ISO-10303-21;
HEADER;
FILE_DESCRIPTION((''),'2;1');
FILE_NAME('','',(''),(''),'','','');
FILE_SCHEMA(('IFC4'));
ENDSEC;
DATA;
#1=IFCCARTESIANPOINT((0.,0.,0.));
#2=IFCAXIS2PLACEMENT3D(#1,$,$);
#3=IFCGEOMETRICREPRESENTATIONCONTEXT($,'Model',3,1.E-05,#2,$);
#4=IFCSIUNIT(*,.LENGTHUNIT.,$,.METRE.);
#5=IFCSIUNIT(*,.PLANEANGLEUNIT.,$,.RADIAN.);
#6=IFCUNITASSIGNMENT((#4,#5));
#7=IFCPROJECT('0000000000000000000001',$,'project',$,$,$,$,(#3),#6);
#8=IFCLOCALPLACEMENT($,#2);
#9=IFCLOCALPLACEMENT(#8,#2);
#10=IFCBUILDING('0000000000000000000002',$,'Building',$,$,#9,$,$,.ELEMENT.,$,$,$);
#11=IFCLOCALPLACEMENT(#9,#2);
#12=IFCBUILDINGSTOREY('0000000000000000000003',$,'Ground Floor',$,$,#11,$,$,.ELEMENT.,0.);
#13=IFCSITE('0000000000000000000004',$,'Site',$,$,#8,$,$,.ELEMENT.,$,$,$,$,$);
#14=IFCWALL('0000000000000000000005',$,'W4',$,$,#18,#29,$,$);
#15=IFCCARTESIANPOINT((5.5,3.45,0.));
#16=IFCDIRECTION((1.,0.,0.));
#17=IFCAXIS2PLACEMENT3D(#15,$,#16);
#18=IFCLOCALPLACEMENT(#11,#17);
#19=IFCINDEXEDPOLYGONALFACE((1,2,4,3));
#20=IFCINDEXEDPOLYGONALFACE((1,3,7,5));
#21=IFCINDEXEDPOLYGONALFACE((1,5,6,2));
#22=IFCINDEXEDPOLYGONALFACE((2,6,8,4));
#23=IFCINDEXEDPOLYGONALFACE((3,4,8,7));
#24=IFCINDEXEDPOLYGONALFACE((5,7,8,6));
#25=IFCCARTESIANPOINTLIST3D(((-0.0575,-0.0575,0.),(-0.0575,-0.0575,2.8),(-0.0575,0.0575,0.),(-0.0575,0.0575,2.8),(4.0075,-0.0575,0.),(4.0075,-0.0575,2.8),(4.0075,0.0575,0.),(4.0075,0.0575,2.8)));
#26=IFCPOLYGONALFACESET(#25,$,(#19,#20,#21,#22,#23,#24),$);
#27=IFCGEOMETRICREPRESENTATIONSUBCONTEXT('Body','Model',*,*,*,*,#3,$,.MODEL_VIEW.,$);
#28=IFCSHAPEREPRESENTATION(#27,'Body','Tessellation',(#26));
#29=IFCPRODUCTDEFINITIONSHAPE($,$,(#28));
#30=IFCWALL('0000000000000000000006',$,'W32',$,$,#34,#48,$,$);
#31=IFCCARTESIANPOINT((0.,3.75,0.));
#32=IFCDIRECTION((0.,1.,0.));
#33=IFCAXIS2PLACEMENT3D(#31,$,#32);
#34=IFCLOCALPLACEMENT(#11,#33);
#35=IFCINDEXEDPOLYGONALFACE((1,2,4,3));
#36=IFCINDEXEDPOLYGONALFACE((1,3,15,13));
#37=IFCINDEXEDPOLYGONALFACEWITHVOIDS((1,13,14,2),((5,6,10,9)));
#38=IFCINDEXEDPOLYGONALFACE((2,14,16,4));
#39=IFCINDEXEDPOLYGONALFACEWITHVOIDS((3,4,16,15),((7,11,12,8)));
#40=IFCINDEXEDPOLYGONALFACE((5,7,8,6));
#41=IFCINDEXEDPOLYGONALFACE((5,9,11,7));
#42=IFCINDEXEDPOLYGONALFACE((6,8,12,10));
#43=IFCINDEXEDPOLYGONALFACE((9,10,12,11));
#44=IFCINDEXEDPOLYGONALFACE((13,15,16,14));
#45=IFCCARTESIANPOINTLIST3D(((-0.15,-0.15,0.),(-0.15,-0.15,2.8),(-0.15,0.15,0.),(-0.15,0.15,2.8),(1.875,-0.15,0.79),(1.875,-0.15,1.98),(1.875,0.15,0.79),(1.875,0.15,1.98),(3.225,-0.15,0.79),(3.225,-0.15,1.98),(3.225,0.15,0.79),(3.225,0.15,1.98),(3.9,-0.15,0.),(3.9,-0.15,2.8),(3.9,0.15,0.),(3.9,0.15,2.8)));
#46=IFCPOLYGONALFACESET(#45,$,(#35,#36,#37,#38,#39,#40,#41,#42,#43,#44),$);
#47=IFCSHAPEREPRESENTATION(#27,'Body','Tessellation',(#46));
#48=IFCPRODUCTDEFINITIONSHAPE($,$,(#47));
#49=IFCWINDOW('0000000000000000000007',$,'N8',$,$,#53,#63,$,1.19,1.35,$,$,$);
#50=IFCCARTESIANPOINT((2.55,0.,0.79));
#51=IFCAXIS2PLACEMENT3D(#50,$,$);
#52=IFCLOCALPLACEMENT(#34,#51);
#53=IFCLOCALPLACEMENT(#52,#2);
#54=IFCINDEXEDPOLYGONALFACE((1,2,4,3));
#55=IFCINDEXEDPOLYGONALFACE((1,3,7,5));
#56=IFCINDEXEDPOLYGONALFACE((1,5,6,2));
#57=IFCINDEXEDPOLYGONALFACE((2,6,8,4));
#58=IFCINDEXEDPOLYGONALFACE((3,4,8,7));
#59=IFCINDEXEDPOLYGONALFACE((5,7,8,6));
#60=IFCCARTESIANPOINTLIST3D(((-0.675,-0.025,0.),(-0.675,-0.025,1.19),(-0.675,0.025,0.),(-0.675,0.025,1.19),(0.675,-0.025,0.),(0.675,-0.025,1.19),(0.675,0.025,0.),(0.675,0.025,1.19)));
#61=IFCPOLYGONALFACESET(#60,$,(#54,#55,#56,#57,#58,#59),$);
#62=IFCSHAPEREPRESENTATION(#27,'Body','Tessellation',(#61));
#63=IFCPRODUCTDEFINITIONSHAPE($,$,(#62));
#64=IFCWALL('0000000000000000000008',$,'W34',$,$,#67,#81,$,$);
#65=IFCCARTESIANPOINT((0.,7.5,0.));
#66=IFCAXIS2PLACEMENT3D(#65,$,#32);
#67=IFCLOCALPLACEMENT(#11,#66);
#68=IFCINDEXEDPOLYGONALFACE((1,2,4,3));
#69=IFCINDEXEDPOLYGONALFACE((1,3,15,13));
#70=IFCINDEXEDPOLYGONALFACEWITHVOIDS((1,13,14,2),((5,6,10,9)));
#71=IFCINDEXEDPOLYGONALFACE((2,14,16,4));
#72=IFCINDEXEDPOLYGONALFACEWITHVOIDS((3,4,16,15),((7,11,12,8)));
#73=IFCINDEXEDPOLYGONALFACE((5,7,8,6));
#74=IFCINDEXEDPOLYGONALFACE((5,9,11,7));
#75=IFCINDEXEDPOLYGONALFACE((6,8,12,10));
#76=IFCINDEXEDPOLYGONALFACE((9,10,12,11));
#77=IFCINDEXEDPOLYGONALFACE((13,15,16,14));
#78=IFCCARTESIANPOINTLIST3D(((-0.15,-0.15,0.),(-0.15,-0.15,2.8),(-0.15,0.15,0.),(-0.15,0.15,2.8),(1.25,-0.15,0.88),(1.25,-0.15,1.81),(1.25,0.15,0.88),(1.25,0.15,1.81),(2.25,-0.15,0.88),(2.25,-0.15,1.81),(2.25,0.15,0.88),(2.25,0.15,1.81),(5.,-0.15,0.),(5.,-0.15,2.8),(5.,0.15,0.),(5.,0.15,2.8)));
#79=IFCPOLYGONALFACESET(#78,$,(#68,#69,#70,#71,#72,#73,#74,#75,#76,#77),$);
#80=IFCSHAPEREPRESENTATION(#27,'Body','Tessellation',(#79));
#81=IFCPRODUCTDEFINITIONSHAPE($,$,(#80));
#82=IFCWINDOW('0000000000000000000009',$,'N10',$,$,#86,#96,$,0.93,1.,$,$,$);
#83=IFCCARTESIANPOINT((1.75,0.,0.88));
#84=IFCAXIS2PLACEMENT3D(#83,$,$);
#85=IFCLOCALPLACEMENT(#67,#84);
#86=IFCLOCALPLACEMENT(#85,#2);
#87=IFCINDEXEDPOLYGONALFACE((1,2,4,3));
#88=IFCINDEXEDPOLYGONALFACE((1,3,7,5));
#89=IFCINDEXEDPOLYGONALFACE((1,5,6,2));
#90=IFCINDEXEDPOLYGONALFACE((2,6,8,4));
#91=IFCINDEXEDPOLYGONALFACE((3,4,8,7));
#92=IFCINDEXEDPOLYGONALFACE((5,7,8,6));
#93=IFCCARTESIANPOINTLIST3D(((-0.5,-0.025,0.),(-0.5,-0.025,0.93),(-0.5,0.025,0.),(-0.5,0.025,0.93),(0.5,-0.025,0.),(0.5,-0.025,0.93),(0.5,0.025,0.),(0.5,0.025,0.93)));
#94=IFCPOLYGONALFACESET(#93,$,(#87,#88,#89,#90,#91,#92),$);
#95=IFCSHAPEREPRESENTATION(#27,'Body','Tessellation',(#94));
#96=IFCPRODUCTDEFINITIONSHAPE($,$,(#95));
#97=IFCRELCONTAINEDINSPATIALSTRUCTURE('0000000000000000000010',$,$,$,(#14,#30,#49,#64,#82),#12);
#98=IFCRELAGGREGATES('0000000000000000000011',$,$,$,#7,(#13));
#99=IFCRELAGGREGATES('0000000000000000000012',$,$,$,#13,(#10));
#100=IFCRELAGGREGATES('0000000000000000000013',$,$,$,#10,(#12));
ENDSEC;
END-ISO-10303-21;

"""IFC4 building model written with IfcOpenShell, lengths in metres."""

from ifc_helpers import new_model, si_unit, frame, frame_2d, origin, origin_2d, place, context, subcontext, project, spatial, rectangle, extrude, element, fill, save


model = new_model("IFC4")

# Units and contexts
model_context = context("Model", 3, precision=1e-05, world=origin())
body_context = subcontext(model_context, "Body", "Model", "MODEL_VIEW")
ifc_project = project(units=[si_unit("LENGTHUNIT", "METRE"), si_unit("PLANEANGLEUNIT", "RADIAN")], contexts=[model_context])

# Site, building, storey
site_placement = place(None, origin())
site = spatial("IfcSite", under=ifc_project, at=site_placement, Name="Site", CompositionType="ELEMENT")
building_placement = place(site_placement, origin())
building = spatial("IfcBuilding", under=site, at=building_placement, Name="Building", CompositionType="ELEMENT")
storey_placement = place(building_placement, origin())
storey = spatial("IfcBuildingStorey", under=building, at=storey_placement, Name="Ground Floor", CompositionType="ELEMENT", Elevation=0.0)

# Wall
wall_1_placement = place(storey_placement, frame((5.5, 3.45, 0.0), x_axis=(1.0, 0.0, 0.0)))
element("IfcWall", 1, at=wall_1_placement, inside=storey, Name="W4", context=body_context, shape_type="SweptSolid", body=[
    extrude(rectangle(XDim=4.065, YDim=0.115, at=frame_2d((1.975, 0.0))), origin(), (0.0, 0.0, 1.0), 2.8),
])

# Walls, openings, windows
wall_2_placement = place(storey_placement, frame((0.0, 3.75, 0.0), x_axis=(0.0, 1.0, 0.0)))
wall_2 = element("IfcWall", 2, at=wall_2_placement, inside=storey, Name="W32", context=body_context, shape_type="SweptSolid", body=[
    extrude(rectangle(XDim=4.05, YDim=0.3, at=frame_2d((1.875, 0.0))), origin(), (0.0, 0.0, 1.0), 2.8),
])
opening_1_placement = place(wall_2_placement, frame((2.55, 0.0, 0.79)))
opening_1 = element("IfcOpeningElement", 3, at=opening_1_placement, cuts=wall_2, context=body_context, shape_type="SweptSolid", body=[
    extrude(rectangle(XDim=1.35, YDim=0.4, at=origin_2d()), origin(), (0.0, 0.0, 1.0), 1.19),
])
window_1_placement = place(opening_1_placement, origin())
window_1 = element("IfcWindow", 4, at=window_1_placement, inside=storey, Name="N8", OverallHeight=1.19, OverallWidth=1.35, context=body_context, shape_type="SweptSolid", body=[
    extrude(rectangle(XDim=1.35, YDim=0.05, at=origin_2d()), origin(), (0.0, 0.0, 1.0), 1.19),
])
fill(opening_1, window_1)
wall_3_placement = place(storey_placement, frame((0.0, 7.5, 0.0), x_axis=(0.0, 1.0, 0.0)))
wall_3 = element("IfcWall", 5, at=wall_3_placement, inside=storey, Name="W34", context=body_context, shape_type="SweptSolid", body=[
    extrude(rectangle(XDim=5.15, YDim=0.3, at=frame_2d((2.425, 0.0))), origin(), (0.0, 0.0, 1.0), 2.8),
])
opening_2_placement = place(wall_3_placement, frame((1.75, 0.0, 0.88)))
opening_2 = element("IfcOpeningElement", 6, at=opening_2_placement, cuts=wall_3, context=body_context, shape_type="SweptSolid", body=[
    extrude(rectangle(XDim=1.0, YDim=0.4, at=origin_2d()), origin(), (0.0, 0.0, 1.0), 0.93),
])
window_2_placement = place(opening_2_placement, origin())
window_2 = element("IfcWindow", 7, at=window_2_placement, inside=storey, Name="N10", OverallHeight=0.93, OverallWidth=1.0, context=body_context, shape_type="SweptSolid", body=[
    extrude(rectangle(XDim=1.0, YDim=0.05, at=origin_2d()), origin(), (0.0, 0.0, 1.0), 0.93),
])
fill(opening_2, window_2)

save(model, "model.ifc")
